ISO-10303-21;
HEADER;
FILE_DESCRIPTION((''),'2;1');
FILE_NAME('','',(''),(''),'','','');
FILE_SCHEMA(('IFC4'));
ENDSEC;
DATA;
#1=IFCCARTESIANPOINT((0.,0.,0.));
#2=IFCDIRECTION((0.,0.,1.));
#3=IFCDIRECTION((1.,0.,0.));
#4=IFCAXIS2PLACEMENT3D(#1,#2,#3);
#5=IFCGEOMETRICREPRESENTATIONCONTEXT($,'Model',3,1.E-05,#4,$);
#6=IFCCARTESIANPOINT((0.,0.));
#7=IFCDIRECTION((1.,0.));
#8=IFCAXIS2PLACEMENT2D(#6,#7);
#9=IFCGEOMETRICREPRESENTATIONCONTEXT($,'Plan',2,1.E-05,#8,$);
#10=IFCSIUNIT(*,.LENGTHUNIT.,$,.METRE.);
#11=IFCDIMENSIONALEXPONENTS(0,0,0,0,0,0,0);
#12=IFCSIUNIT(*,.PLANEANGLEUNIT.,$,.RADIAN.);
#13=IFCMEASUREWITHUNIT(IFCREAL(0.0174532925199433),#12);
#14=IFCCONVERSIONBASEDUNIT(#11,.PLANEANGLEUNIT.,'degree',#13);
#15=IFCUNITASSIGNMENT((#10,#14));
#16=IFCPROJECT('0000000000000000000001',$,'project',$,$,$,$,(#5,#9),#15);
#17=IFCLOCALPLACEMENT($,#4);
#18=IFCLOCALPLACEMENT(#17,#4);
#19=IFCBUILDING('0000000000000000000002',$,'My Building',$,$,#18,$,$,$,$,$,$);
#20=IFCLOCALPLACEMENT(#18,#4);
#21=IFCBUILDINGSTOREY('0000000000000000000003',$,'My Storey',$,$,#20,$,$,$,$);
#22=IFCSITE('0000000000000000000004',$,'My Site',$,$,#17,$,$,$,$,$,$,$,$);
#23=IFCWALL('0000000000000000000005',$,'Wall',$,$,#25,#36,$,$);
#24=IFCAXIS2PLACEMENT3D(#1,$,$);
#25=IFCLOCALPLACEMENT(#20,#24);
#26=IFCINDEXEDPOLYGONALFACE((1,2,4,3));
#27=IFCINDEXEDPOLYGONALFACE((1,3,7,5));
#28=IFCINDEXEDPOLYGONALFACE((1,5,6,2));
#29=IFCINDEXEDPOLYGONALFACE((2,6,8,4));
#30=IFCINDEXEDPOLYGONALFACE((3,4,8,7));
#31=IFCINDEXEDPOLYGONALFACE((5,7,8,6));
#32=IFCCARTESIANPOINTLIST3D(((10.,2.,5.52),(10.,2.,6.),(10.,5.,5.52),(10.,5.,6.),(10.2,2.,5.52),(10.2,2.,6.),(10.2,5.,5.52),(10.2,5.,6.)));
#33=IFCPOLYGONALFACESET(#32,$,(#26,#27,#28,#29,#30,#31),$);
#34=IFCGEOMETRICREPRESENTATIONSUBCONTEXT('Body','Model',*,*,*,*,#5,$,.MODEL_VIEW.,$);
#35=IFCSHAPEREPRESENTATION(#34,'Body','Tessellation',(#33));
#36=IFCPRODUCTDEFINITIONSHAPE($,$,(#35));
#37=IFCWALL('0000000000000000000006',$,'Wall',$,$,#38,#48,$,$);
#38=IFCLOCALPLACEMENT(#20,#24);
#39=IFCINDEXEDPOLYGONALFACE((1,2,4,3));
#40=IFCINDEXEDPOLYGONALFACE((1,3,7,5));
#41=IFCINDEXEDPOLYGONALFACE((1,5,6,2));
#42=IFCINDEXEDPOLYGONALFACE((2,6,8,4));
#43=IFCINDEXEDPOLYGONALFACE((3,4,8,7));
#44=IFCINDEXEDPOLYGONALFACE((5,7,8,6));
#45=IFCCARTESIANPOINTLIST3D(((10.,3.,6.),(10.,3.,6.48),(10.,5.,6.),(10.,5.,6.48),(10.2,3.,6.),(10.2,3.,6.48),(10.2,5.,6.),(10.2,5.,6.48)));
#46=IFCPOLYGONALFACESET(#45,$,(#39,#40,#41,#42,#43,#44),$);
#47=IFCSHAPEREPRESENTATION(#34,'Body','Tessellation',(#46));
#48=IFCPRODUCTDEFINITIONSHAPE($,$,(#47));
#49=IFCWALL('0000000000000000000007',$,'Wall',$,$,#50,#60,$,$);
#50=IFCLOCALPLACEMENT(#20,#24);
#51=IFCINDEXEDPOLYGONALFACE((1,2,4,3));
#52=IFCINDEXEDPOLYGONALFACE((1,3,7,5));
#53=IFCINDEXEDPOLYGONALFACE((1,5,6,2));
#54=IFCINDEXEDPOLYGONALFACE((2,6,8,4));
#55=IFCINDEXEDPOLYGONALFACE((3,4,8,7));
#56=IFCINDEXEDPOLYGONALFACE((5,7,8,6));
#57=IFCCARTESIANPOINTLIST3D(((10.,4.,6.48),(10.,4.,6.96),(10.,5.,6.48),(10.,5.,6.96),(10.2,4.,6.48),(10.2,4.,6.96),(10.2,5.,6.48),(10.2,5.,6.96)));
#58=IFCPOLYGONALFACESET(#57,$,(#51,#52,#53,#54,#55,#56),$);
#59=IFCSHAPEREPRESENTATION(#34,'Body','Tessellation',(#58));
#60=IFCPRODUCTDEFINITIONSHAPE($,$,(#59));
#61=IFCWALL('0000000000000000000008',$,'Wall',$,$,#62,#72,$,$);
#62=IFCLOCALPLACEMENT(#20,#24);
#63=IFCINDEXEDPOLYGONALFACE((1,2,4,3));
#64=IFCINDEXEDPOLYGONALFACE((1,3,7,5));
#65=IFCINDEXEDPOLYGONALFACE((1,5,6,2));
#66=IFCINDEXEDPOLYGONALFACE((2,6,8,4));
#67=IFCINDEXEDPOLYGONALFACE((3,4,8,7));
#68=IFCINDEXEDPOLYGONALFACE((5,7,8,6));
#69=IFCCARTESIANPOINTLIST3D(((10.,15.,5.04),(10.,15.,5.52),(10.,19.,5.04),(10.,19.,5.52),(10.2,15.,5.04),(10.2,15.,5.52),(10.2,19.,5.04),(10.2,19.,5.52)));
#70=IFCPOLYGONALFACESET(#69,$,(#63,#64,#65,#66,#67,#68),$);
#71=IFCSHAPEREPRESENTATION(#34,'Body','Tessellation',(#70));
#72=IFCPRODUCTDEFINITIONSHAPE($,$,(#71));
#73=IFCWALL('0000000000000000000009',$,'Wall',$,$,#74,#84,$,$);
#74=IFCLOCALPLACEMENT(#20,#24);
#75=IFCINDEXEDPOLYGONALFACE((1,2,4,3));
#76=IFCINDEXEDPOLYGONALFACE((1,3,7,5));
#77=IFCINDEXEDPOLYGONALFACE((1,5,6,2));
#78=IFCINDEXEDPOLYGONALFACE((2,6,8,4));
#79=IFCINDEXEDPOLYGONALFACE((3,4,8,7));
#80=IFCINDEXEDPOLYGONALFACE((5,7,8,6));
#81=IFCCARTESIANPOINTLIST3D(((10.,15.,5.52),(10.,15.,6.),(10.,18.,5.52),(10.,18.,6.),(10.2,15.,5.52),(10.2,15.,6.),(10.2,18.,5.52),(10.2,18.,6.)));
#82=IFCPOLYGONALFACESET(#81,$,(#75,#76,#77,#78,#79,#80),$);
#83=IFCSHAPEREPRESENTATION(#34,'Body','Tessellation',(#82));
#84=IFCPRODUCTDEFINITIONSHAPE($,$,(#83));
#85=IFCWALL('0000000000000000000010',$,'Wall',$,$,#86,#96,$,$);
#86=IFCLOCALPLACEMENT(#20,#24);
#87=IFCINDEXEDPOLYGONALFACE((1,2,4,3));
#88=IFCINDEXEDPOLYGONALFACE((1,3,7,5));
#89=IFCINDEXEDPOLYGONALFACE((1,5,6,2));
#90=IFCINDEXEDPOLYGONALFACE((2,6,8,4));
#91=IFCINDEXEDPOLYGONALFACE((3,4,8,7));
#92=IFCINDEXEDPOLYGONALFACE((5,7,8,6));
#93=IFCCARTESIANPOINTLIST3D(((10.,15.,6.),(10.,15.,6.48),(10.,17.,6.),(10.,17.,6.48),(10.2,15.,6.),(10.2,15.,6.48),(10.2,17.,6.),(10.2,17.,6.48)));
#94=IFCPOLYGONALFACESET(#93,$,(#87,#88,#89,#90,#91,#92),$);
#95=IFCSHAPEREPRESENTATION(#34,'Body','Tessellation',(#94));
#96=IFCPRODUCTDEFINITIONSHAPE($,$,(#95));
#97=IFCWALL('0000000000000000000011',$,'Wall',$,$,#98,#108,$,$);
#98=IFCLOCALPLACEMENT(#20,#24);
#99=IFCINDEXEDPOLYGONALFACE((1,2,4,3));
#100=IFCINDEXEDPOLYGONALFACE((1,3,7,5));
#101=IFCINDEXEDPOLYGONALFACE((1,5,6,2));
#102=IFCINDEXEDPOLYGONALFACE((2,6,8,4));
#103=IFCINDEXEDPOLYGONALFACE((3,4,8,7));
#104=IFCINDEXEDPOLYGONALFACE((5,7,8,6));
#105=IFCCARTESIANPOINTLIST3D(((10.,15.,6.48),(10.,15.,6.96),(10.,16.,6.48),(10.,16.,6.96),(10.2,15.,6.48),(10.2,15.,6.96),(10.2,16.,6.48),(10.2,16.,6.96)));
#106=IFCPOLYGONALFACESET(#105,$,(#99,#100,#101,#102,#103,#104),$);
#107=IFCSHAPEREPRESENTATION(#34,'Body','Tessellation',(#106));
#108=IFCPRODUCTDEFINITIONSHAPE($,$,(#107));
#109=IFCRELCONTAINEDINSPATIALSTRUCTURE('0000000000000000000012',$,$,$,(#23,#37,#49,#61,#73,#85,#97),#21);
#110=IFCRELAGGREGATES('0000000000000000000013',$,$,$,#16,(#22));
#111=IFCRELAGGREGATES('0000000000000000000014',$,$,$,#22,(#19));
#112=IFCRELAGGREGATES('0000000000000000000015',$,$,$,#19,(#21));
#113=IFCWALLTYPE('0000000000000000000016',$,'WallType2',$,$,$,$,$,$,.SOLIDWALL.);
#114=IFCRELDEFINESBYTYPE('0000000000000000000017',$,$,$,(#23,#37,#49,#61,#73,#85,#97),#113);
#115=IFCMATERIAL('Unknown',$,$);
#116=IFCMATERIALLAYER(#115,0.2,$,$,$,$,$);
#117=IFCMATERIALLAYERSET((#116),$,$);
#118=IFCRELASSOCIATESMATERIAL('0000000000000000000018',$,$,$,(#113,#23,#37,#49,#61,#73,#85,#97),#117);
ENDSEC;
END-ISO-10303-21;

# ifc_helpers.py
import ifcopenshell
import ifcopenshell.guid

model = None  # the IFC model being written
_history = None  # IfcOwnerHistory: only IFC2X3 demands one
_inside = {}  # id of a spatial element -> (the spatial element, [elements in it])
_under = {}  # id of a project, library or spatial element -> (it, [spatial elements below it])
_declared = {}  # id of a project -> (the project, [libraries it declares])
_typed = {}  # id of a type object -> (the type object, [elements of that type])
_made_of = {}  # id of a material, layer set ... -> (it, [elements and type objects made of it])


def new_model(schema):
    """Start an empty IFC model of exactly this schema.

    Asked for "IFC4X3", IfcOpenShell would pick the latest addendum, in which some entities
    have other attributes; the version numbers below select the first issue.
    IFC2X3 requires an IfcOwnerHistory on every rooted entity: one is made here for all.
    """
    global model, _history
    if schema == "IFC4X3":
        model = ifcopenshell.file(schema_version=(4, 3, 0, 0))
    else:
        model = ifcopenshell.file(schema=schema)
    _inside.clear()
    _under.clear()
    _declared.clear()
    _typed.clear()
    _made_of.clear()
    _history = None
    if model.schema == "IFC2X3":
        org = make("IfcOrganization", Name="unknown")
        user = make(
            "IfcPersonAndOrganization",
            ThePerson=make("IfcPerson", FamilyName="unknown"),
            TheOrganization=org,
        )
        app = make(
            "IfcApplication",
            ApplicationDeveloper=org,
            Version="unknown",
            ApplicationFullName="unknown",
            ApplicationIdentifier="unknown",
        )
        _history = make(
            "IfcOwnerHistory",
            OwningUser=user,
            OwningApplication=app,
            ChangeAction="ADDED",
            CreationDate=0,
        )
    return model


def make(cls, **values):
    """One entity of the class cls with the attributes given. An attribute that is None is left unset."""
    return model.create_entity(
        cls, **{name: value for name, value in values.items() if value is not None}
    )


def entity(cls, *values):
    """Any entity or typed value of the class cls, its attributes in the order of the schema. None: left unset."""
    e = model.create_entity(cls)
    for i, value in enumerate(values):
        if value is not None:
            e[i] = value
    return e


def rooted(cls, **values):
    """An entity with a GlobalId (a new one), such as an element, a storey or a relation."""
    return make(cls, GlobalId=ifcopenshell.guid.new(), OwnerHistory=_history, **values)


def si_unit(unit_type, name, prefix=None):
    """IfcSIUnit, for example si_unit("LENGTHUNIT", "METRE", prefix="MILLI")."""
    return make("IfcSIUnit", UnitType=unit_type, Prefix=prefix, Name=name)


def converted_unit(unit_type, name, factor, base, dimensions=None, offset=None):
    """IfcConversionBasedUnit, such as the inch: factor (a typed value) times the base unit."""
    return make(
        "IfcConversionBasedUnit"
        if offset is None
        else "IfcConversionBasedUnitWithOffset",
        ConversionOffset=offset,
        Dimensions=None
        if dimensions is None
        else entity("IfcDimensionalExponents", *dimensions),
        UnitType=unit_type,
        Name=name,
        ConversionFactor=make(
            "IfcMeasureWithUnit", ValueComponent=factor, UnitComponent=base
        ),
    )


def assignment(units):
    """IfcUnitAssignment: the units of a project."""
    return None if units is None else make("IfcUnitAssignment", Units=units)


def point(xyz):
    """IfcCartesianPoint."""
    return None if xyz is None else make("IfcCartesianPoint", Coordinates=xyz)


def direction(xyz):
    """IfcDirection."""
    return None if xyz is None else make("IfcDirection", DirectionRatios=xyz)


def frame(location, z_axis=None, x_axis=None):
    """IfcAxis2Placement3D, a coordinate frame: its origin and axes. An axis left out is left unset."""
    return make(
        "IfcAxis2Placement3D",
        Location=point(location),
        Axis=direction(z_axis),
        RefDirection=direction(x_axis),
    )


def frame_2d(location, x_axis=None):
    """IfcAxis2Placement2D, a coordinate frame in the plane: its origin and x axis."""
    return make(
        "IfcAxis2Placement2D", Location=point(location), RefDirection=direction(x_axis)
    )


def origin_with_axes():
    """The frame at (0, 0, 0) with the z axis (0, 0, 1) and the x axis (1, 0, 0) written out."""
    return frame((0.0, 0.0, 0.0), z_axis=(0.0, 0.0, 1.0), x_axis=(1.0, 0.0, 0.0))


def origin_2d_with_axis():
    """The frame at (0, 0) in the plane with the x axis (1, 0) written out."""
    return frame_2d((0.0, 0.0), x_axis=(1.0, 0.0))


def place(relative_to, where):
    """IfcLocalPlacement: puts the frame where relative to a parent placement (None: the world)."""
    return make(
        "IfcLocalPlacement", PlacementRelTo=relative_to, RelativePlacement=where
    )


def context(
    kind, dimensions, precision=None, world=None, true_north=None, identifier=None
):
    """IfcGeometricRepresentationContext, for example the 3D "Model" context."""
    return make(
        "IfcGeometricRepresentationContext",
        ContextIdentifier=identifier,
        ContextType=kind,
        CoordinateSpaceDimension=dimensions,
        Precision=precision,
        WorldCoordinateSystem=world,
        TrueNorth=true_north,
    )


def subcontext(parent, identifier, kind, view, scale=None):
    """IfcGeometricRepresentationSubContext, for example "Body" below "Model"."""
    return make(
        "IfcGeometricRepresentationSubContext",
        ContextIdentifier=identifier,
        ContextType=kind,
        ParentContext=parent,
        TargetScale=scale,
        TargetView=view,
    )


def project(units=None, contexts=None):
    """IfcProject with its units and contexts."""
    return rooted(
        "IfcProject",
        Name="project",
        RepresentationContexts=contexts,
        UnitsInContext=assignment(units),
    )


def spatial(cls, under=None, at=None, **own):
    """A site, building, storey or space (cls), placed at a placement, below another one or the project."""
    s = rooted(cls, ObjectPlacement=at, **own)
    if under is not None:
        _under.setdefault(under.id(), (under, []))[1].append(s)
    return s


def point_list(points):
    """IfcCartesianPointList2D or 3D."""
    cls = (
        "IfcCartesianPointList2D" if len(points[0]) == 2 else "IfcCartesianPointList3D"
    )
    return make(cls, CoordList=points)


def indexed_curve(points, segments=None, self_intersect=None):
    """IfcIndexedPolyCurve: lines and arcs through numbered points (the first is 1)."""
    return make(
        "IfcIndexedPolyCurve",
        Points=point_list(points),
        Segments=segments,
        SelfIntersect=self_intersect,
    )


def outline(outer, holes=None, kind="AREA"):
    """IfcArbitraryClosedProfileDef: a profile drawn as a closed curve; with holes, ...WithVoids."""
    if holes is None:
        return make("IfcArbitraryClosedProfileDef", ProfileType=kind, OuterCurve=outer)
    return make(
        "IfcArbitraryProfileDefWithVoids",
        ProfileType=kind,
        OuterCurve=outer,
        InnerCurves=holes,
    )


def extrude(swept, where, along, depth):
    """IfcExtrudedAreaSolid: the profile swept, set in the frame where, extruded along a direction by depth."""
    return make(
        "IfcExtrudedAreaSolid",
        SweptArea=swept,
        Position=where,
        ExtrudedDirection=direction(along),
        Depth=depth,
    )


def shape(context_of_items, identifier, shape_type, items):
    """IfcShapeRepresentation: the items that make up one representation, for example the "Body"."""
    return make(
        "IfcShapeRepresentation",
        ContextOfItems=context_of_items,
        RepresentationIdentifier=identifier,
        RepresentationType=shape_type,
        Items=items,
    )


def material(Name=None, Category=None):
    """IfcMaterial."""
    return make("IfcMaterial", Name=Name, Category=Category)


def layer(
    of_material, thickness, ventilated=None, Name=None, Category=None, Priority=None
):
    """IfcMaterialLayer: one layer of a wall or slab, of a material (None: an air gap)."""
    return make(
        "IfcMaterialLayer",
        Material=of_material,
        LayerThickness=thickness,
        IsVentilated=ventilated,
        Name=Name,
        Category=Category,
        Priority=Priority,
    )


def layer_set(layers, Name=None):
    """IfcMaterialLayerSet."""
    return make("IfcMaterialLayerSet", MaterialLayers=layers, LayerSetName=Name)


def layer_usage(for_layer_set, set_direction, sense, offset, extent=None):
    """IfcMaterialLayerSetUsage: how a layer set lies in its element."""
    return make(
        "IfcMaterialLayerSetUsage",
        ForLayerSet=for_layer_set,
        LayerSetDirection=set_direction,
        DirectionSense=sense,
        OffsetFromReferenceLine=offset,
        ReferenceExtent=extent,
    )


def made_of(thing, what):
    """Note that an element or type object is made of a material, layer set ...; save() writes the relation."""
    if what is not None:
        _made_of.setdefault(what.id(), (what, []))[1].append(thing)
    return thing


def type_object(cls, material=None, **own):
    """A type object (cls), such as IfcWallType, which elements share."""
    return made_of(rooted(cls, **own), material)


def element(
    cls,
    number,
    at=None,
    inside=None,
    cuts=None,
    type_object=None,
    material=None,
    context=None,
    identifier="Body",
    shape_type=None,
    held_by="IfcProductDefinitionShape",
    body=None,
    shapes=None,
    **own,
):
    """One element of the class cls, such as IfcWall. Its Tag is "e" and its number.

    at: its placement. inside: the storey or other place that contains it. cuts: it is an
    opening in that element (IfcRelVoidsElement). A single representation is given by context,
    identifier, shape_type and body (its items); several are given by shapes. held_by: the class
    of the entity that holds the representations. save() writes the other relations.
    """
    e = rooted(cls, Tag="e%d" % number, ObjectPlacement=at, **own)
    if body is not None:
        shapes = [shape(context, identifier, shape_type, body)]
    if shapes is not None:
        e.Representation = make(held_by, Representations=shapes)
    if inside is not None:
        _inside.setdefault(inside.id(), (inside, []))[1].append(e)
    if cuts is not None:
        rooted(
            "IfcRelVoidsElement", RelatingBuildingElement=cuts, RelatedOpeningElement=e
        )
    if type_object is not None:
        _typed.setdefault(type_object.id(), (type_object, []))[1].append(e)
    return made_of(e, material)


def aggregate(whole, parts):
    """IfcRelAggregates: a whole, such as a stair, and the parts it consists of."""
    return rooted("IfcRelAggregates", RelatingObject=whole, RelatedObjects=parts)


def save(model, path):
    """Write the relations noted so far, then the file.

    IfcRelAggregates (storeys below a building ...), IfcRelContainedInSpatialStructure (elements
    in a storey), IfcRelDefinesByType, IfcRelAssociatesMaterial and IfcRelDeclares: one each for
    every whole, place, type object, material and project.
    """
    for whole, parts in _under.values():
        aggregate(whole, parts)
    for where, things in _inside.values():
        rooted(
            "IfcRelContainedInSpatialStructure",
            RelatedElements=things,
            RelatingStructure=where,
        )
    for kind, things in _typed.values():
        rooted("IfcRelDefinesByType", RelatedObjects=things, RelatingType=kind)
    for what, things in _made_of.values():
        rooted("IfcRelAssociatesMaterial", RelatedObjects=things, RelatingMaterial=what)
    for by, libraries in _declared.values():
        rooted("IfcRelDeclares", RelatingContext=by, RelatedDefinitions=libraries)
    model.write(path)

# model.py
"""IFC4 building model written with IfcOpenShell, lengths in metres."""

from ifc_helpers import new_model, entity, si_unit, converted_unit, frame, origin_with_axes, origin_2d_with_axis, place, context, subcontext, project, spatial, indexed_curve, outline, extrude, material, layer, layer_set, layer_usage, type_object, element, save


model = new_model("IFC4")

# Units and contexts
model_context = context("Model", 3, precision=1e-05, world=origin_with_axes())
plan_context = context("Plan", 2, precision=1e-05, world=origin_2d_with_axis())
body_context_1 = subcontext(model_context, "Body", "Model", "MODEL_VIEW")
ifc_project = project(units=[si_unit("LENGTHUNIT", "METRE"), converted_unit("PLANEANGLEUNIT", "degree", entity("IfcReal", 0.0174532925199433), si_unit("PLANEANGLEUNIT", "RADIAN"), dimensions=[0, 0, 0, 0, 0, 0, 0])], contexts=[model_context, plan_context])

# Site, building, storey
site_placement = place(None, origin_with_axes())
site = spatial("IfcSite", under=ifc_project, at=site_placement, Name="My Site")
building_placement = place(site_placement, origin_with_axes())
building = spatial("IfcBuilding", under=site, at=building_placement, Name="My Building")
storey_placement = place(building_placement, origin_with_axes())
storey = spatial("IfcBuildingStorey", under=building, at=storey_placement, Name="My Storey")

# Walls
ifc_material = material(Name="Unknown")
ifc_layer_1 = layer(ifc_material, 0.2)
ifc_layer_set_1 = layer_set([ifc_layer_1])
ifc_layer_usage_1 = layer_usage(ifc_layer_set_1, "AXIS2", "POSITIVE", 0.0)
wall_type_1 = type_object("IfcWallType", Name="WallType2", PredefinedType="SOLIDWALL", material=ifc_layer_set_1)
wall_1_placement = place(storey_placement, frame((10.2, 2.0, 5.52), z_axis=(0.0, 0.0, 1.0), x_axis=(0.0, 1.0, 0.0)))
element("IfcWall", 1, at=wall_1_placement, inside=storey, type_object=wall_type_1, material=ifc_layer_usage_1, Name="Wall", context=body_context_1, shape_type="SweptSolid", body=[
    extrude(outline(indexed_curve([(0.0, 0.0), (0.0, 0.2), (3.0, 0.2), (3.0, 0.0), (0.0, 0.0)], self_intersect=False)), origin_with_axes(), (0.0, 0.0, 1.0), 0.48),
])
ifc_layer_usage_2 = layer_usage(ifc_layer_set_1, "AXIS2", "POSITIVE", 0.0)
wall_2_placement = place(storey_placement, frame((10.2, 3.0, 6.0), z_axis=(0.0, 0.0, 1.0), x_axis=(0.0, 1.0, 0.0)))
element("IfcWall", 2, at=wall_2_placement, inside=storey, type_object=wall_type_1, material=ifc_layer_usage_2, Name="Wall", context=body_context_1, shape_type="SweptSolid", body=[
    extrude(outline(indexed_curve([(0.0, 0.0), (0.0, 0.2), (2.0, 0.2), (2.0, 0.0), (0.0, 0.0)], self_intersect=False)), origin_with_axes(), (0.0, 0.0, 1.0), 0.48),
])
ifc_layer_usage_3 = layer_usage(ifc_layer_set_1, "AXIS2", "POSITIVE", 0.0)
wall_3_placement = place(storey_placement, frame((10.2, 4.0, 6.48), z_axis=(0.0, 0.0, 1.0), x_axis=(0.0, 1.0, 0.0)))
element("IfcWall", 3, at=wall_3_placement, inside=storey, type_object=wall_type_1, material=ifc_layer_usage_3, Name="Wall", context=body_context_1, shape_type="SweptSolid", body=[
    extrude(outline(indexed_curve([(0.0, 0.0), (0.0, 0.2), (1.0, 0.2), (1.0, 0.0), (0.0, 0.0)], self_intersect=False)), origin_with_axes(), (0.0, 0.0, 1.0), 0.48),
])
ifc_layer_usage_4 = layer_usage(ifc_layer_set_1, "AXIS2", "POSITIVE", 0.0)
wall_4_placement = place(storey_placement, frame((10.2, 15.0, 5.04), z_axis=(0.0, 0.0, 1.0), x_axis=(0.0, 1.0, 0.0)))
element("IfcWall", 4, at=wall_4_placement, inside=storey, type_object=wall_type_1, material=ifc_layer_usage_4, Name="Wall", context=body_context_1, shape_type="SweptSolid", body=[
    extrude(outline(indexed_curve([(0.0, 0.0), (0.0, 0.2), (4.0, 0.2), (4.0, 0.0), (0.0, 0.0)], self_intersect=False)), origin_with_axes(), (0.0, 0.0, 1.0), 0.48),
])
ifc_layer_usage_5 = layer_usage(ifc_layer_set_1, "AXIS2", "POSITIVE", 0.0)
wall_5_placement = place(storey_placement, frame((10.2, 15.0, 5.52), z_axis=(0.0, 0.0, 1.0), x_axis=(0.0, 1.0, 0.0)))
element("IfcWall", 5, at=wall_5_placement, inside=storey, type_object=wall_type_1, material=ifc_layer_usage_5, Name="Wall", context=body_context_1, shape_type="SweptSolid", body=[
    extrude(outline(indexed_curve([(0.0, 0.0), (0.0, 0.2), (3.0, 0.2), (3.0, 0.0), (0.0, 0.0)], self_intersect=False)), origin_with_axes(), (0.0, 0.0, 1.0), 0.48),
])
ifc_layer_usage_6 = layer_usage(ifc_layer_set_1, "AXIS2", "POSITIVE", 0.0)
wall_6_placement = place(storey_placement, frame((10.2, 15.0, 6.0), z_axis=(0.0, 0.0, 1.0), x_axis=(0.0, 1.0, 0.0)))
element("IfcWall", 6, at=wall_6_placement, inside=storey, type_object=wall_type_1, material=ifc_layer_usage_6, Name="Wall", context=body_context_1, shape_type="SweptSolid", body=[
    extrude(outline(indexed_curve([(0.0, 0.0), (0.0, 0.2), (2.0, 0.2), (2.0, 0.0), (0.0, 0.0)], self_intersect=False)), origin_with_axes(), (0.0, 0.0, 1.0), 0.48),
])
ifc_layer_usage_7 = layer_usage(ifc_layer_set_1, "AXIS2", "POSITIVE", 0.0)
wall_7_placement = place(storey_placement, frame((10.2, 15.0, 6.48), z_axis=(0.0, 0.0, 1.0), x_axis=(0.0, 1.0, 0.0)))
element("IfcWall", 7, at=wall_7_placement, inside=storey, type_object=wall_type_1, material=ifc_layer_usage_7, Name="Wall", context=body_context_1, shape_type="SweptSolid", body=[
    extrude(outline(indexed_curve([(0.0, 0.0), (0.0, 0.2), (1.0, 0.2), (1.0, 0.0), (0.0, 0.0)], self_intersect=False)), origin_with_axes(), (0.0, 0.0, 1.0), 0.48),
])

save(model, "model.ifc")
